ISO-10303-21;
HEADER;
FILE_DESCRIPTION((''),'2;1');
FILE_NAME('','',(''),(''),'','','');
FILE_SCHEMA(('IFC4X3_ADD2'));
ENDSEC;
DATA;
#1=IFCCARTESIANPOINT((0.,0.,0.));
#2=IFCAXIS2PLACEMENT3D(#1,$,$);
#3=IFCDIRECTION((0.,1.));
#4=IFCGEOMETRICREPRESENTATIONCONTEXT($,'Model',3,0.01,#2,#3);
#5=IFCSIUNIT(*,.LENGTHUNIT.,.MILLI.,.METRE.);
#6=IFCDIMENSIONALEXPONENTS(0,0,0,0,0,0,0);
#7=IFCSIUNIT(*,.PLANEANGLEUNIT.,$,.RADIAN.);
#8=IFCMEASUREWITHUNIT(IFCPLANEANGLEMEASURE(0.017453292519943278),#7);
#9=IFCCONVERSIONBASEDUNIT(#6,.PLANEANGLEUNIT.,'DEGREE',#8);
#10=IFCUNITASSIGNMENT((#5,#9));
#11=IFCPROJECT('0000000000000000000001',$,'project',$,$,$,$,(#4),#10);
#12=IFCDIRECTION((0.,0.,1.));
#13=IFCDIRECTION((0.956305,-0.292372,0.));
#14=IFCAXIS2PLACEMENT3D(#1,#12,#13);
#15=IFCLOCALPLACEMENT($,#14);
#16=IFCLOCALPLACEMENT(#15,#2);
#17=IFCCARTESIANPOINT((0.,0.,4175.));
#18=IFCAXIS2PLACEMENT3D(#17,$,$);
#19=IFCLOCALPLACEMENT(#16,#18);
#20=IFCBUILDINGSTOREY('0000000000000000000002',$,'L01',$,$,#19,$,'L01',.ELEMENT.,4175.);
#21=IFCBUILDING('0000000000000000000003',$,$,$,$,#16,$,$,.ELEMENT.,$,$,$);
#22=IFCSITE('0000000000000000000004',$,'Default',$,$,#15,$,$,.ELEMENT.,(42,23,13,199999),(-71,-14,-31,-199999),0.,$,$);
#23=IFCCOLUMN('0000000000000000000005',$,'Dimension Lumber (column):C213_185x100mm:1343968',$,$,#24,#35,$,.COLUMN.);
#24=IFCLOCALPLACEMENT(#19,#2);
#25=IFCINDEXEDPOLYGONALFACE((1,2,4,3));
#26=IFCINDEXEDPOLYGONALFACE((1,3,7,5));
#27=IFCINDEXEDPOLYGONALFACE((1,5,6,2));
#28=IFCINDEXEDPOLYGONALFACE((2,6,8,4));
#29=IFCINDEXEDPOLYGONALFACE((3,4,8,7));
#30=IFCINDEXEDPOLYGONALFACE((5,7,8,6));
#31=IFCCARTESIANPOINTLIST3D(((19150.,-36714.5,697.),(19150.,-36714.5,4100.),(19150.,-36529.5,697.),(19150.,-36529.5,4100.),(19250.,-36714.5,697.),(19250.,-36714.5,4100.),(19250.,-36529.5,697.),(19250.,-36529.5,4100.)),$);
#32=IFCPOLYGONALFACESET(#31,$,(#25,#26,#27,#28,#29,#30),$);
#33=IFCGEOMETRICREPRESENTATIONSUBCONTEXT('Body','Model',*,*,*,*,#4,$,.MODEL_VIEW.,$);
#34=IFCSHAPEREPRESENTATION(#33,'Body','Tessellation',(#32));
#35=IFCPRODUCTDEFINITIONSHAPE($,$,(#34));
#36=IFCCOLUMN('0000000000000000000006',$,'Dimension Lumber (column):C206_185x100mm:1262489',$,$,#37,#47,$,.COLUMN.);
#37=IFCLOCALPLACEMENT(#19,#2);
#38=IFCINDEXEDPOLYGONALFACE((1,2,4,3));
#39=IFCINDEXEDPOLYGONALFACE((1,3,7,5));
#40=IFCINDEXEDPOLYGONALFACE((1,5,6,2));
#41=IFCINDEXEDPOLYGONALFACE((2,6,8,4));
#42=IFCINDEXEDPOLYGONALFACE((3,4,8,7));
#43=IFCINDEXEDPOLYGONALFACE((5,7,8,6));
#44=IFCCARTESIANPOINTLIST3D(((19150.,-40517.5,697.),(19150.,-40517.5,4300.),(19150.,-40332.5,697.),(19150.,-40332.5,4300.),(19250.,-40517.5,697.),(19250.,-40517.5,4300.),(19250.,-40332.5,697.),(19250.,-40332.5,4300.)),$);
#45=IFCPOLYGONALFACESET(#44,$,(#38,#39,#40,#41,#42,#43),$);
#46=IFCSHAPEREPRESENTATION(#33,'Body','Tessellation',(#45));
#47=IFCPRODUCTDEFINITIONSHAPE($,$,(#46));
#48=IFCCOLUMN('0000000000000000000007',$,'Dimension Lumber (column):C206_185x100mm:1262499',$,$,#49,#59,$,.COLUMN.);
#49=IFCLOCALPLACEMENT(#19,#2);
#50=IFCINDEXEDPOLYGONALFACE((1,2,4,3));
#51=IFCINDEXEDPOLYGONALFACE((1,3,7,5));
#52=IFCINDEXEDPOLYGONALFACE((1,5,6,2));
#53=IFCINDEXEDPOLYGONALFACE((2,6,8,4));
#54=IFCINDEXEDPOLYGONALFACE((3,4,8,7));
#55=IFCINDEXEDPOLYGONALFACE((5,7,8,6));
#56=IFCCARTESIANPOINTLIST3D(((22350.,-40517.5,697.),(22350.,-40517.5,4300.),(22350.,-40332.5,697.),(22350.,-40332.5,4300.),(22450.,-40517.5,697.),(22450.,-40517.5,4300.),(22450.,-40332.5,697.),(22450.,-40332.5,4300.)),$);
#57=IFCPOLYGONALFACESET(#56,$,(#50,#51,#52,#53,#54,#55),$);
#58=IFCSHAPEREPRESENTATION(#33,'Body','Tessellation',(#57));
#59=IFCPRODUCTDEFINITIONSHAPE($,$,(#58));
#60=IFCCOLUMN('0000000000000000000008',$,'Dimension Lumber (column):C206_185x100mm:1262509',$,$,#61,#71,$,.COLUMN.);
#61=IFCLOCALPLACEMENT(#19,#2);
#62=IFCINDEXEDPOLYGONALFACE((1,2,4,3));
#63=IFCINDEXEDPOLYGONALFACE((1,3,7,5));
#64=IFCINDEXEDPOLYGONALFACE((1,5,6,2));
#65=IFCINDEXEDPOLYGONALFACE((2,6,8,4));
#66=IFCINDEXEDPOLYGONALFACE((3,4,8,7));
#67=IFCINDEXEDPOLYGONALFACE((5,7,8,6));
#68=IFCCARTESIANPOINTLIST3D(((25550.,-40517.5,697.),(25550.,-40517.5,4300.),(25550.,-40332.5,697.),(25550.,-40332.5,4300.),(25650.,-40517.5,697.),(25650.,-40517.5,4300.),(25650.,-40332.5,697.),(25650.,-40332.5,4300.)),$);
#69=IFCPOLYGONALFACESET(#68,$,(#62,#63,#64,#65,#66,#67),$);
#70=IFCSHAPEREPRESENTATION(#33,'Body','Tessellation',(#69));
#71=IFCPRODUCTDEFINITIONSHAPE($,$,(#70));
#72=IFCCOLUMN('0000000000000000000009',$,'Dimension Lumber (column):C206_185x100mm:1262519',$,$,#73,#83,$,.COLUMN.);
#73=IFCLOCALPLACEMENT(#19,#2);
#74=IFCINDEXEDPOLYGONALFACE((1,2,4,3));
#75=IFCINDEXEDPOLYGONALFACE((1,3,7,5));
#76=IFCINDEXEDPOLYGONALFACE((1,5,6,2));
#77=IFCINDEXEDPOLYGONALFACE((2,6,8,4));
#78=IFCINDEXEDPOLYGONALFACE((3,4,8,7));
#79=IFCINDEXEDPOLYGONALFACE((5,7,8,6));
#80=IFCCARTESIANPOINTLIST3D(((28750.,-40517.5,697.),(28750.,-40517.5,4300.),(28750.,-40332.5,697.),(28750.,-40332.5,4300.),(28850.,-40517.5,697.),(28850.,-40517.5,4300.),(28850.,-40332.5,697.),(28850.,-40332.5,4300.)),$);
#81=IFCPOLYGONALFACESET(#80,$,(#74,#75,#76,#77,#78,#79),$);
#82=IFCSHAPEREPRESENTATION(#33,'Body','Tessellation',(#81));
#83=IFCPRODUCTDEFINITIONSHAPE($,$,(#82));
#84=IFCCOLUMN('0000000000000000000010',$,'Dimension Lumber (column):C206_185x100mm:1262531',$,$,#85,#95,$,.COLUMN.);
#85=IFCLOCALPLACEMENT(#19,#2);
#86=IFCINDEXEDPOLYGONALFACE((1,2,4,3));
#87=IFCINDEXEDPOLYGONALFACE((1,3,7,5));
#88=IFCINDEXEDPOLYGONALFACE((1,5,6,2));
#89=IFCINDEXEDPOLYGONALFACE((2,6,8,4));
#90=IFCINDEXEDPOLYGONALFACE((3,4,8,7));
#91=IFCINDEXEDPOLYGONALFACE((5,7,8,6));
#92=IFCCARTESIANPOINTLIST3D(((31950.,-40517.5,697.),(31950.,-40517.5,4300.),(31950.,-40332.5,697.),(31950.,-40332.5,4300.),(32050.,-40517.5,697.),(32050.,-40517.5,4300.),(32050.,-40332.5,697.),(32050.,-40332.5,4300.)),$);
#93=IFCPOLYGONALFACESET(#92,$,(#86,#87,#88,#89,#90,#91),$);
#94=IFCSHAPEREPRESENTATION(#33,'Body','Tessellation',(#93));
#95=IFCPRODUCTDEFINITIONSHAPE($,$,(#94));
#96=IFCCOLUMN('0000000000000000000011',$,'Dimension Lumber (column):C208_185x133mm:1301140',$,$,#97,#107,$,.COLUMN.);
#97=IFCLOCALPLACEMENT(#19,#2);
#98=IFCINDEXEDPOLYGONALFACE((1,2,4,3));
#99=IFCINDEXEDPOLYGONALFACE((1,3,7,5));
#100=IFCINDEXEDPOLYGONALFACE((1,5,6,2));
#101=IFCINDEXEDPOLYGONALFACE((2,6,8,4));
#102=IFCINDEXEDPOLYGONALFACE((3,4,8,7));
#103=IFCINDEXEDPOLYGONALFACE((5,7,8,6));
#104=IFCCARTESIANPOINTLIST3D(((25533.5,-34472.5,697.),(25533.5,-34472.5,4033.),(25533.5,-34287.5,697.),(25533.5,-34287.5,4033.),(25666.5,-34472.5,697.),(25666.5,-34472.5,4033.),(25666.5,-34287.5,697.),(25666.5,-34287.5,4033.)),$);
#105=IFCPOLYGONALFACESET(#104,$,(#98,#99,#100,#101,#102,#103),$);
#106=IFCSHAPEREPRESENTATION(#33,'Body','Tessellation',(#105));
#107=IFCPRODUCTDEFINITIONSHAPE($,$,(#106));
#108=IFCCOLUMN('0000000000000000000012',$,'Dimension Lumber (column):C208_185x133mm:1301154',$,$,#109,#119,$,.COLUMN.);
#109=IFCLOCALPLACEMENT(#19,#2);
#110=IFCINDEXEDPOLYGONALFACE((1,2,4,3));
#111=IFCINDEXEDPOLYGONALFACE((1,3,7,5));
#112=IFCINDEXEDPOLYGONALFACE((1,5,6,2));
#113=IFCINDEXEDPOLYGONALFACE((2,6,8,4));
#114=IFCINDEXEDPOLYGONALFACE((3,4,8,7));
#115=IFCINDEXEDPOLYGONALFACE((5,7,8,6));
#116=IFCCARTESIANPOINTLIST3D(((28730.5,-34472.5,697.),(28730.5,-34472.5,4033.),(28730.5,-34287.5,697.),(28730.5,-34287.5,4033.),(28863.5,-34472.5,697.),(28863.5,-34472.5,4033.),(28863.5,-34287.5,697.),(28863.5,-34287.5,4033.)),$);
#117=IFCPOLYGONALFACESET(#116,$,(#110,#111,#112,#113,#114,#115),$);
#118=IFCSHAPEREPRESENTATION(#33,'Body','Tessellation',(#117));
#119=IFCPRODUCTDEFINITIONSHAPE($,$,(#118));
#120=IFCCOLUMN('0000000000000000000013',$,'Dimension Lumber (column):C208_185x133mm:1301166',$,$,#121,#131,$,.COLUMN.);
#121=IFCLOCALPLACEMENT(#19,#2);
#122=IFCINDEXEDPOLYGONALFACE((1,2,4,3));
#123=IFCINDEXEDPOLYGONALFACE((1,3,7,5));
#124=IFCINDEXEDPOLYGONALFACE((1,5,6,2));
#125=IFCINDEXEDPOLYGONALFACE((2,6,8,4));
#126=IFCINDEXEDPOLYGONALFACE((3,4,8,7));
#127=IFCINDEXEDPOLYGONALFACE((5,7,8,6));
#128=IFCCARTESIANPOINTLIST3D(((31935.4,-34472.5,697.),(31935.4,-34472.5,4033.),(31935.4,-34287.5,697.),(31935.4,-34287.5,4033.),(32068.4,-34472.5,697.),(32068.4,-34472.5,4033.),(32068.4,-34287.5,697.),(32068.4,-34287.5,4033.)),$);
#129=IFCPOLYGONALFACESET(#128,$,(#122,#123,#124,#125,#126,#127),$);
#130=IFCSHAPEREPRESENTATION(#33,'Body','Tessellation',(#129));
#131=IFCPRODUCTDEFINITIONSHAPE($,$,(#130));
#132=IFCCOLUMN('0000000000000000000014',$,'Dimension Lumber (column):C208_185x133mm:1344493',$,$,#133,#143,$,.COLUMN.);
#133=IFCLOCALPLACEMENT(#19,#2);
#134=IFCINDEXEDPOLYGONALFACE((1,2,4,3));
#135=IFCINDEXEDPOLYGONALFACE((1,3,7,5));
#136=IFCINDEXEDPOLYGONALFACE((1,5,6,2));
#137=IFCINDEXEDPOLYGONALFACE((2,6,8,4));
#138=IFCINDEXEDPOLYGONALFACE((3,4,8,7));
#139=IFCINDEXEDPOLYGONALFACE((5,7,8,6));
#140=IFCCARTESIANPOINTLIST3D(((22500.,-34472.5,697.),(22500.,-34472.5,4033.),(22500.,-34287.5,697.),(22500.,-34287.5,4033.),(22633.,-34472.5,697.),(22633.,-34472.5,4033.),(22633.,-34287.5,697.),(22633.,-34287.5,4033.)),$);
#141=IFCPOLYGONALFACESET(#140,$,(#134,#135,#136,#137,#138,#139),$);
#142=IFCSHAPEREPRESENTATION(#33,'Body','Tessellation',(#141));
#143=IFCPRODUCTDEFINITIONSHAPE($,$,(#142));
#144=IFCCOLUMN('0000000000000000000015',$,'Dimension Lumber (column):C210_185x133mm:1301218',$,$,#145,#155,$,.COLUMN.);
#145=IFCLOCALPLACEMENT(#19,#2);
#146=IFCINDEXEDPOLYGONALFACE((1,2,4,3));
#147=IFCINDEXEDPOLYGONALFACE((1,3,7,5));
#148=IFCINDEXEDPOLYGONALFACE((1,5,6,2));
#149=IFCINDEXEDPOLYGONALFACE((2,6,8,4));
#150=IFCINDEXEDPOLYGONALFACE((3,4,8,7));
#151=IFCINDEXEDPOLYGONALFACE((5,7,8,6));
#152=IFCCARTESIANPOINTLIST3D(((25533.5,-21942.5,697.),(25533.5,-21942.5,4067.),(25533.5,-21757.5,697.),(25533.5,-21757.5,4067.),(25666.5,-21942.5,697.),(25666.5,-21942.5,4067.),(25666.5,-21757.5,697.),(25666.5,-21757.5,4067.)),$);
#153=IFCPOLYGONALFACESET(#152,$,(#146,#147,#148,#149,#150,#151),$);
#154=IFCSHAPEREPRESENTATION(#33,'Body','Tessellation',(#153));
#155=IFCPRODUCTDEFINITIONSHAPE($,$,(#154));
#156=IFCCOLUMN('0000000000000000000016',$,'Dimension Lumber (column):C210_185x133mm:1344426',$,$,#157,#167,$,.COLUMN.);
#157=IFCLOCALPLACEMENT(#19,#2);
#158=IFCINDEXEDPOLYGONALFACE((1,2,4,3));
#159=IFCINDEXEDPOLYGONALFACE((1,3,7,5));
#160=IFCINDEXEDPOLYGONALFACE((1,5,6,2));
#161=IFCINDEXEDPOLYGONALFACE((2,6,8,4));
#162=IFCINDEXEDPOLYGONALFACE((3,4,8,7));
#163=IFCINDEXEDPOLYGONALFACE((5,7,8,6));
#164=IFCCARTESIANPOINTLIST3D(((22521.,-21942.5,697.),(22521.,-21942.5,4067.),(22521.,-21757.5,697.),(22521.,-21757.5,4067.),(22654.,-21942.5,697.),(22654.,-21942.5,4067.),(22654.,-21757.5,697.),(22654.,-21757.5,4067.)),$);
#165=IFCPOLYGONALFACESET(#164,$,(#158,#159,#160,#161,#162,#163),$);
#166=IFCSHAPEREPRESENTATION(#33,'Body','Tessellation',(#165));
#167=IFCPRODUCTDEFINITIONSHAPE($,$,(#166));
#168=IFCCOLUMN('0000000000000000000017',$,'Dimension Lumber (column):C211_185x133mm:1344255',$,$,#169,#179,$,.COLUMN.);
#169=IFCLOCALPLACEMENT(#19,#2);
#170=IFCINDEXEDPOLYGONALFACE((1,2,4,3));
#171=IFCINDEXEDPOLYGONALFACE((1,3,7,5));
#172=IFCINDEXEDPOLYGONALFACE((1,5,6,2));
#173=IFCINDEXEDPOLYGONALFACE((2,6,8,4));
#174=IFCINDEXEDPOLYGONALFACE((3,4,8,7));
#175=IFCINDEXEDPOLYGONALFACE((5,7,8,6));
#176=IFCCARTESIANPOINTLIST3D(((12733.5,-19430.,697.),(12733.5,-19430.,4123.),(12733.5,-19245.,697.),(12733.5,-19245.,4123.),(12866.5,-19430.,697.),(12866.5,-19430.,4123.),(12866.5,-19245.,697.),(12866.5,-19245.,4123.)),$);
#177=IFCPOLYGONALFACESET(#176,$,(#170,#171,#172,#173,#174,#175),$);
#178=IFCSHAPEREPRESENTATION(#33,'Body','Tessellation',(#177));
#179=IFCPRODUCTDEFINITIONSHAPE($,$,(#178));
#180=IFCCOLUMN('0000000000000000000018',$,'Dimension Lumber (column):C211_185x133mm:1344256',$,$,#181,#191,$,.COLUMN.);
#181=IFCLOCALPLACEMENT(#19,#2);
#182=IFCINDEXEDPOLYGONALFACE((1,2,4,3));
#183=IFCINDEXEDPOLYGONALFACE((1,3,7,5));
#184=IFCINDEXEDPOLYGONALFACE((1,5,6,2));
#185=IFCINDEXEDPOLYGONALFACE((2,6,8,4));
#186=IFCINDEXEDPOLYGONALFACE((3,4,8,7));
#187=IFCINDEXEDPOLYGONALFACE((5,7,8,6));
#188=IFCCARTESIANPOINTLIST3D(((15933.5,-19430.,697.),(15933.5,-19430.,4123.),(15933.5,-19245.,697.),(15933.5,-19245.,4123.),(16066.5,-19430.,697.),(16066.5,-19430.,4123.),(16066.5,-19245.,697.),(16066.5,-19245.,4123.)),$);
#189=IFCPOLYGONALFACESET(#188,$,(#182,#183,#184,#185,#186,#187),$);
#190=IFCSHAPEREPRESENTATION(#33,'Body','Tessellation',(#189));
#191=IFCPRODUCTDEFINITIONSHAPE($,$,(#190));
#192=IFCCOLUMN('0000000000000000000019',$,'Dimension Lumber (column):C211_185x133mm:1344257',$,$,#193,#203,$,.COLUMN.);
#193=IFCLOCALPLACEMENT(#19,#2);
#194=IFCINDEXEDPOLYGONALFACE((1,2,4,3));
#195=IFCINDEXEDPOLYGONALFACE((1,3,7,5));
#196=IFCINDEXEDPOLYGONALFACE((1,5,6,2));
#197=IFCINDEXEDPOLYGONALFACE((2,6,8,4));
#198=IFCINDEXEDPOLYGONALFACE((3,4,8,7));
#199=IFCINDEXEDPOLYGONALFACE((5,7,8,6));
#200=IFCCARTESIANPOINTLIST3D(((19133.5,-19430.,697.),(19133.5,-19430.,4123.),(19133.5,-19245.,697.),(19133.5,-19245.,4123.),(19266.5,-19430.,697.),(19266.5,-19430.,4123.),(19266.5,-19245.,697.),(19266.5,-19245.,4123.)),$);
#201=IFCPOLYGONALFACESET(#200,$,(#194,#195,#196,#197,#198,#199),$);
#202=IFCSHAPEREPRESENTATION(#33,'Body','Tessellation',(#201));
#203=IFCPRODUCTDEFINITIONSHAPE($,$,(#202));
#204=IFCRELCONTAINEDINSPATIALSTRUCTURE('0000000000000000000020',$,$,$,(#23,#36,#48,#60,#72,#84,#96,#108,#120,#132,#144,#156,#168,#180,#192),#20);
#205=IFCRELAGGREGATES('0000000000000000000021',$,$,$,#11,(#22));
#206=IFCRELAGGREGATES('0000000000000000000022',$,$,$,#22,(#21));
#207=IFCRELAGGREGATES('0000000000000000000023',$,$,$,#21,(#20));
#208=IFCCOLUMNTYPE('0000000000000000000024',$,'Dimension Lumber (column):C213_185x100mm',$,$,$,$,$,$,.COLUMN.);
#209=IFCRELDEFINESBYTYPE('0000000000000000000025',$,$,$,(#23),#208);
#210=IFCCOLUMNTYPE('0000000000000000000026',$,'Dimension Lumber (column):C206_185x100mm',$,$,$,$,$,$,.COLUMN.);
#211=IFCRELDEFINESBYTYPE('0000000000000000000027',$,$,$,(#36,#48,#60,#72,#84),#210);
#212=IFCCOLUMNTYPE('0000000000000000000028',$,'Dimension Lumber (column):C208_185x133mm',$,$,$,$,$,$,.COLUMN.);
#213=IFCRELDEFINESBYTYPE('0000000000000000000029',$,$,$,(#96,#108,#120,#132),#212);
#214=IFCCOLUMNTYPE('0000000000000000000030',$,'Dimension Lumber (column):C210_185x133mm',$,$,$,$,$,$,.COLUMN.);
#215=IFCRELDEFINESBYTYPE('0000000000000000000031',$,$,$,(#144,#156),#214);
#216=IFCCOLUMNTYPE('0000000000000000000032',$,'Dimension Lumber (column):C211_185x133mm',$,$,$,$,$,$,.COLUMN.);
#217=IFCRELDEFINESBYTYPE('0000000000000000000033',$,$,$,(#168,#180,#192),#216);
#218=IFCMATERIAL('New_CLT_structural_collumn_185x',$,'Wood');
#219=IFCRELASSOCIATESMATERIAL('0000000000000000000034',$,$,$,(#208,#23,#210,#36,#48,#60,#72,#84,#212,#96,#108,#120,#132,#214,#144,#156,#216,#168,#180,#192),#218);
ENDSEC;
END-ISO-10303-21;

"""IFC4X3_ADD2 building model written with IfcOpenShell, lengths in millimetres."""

from ifc_helpers import new_model, entity, si_unit, converted_unit, direction, frame, origin, origin_2d_with_axis, place, context, subcontext, project, spatial, rectangle, extrude, source, transform, mapped, material, material_profile, profile_set, profile_usage, type_object, type_shapes, element, save


model = new_model("IFC4X3_ADD2")

# Units and contexts
model_context = context("Model", 3, precision=0.01, world=origin(), true_north=direction((0.0, 1.0)))
body_context = subcontext(model_context, "Body", "Model", "MODEL_VIEW")
ifc_project = project(units=[si_unit("LENGTHUNIT", "METRE", prefix="MILLI"), converted_unit("PLANEANGLEUNIT", "DEGREE", entity("IfcPlaneAngleMeasure", 0.017453292519943278), si_unit("PLANEANGLEUNIT", "RADIAN"), dimensions=[0, 0, 0, 0, 0, 0, 0])], contexts=[model_context])

# Site, building, storey
site_placement = place(None, frame((0.0, 0.0, 0.0), z_axis=(0.0, 0.0, 1.0), x_axis=(0.956305, -0.292372, 0.0)))
site = spatial("IfcSite", under=ifc_project, at=site_placement, Name="Default", CompositionType="ELEMENT", RefLatitude=(42, 23, 13, 199999), RefLongitude=(-71, -14, -31, -199999), RefElevation=0.0)
building_placement = place(site_placement, origin())
building = spatial("IfcBuilding", under=site, at=building_placement, CompositionType="ELEMENT")
storey_placement = place(building_placement, frame((0.0, 0.0, 4175.0)))
storey = spatial("IfcBuildingStorey", under=building, at=storey_placement, Name="L01", LongName="L01", CompositionType="ELEMENT", Elevation=4175.0)

# Columns
ifc_material_1 = material(Name="New_CLT_structural_collumn_185x", Category="Wood")
ifc_material_profile_1 = material_profile(ifc_material_1, rectangle(XDim=185.0, YDim=100.0, at=origin_2d_with_axis()), Name="C213_185x100mm")
ifc_profile_set_1 = profile_set([ifc_material_profile_1], Name="C213_185x100mm")
ifc_profile_usage_1 = profile_usage(ifc_profile_set_1)
column_type_1 = type_object("IfcColumnType", Name="Dimension Lumber (column):C213_185x100mm", PredefinedType="COLUMN", material=ifc_profile_set_1)
shared_shape_1 = source(origin(), body_context, "Body", "SweptSolid", [
    extrude(rectangle(XDim=185.0, YDim=100.0, at=origin_2d_with_axis()), frame((0.0, 0.0, 4872.0), z_axis=(0.0, 0.0, 1.0), x_axis=(-1.0, 0.0, 0.0)), (0.0, 0.0, 1.0), 3403.0),
])
type_shapes(column_type_1, [shared_shape_1])
column_placement = place(storey_placement, frame((19200.0, -36622.0, -4175.0), z_axis=(0.0, 0.0, 1.0), x_axis=(0.0, -1.0, 0.0)))
element("IfcColumn", 1, at=column_placement, inside=storey, type_object=column_type_1, material=ifc_profile_usage_1, Name="Dimension Lumber (column):C213_185x100mm:1343968", PredefinedType="COLUMN", context=body_context, shape_type="MappedRepresentation", body=[
    mapped(shared_shape_1, transform((0.0, 0.0, 0.0), scale=1.0)),
])
ifc_material_profile_2 = material_profile(ifc_material_1, rectangle(XDim=185.0, YDim=100.0, at=origin_2d_with_axis()), Name="C206_185x100mm")
ifc_profile_set_2 = profile_set([ifc_material_profile_2], Name="C206_185x100mm")
ifc_profile_usage_2 = profile_usage(ifc_profile_set_2)
column_type_2 = type_object("IfcColumnType", Name="Dimension Lumber (column):C206_185x100mm", PredefinedType="COLUMN", material=ifc_profile_set_2)
shared_shape_2 = source(origin(), body_context, "Body", "SweptSolid", [
    extrude(rectangle(XDim=185.0, YDim=100.0, at=origin_2d_with_axis()), frame((0.0, 0.0, 4872.0), z_axis=(0.0, 0.0, 1.0), x_axis=(-1.0, 0.0, 0.0)), (0.0, 0.0, 1.0), 3603.0),
])
type_shapes(column_type_2, [shared_shape_2])
for number, where, z_axis, x_axis, name in (
    (2, (19200.0, -40425.0, -4175.0), (0.0, 0.0, 1.0), (0.0, 1.0, 0.0), "Dimension Lumber (column):C206_185x100mm:1262489"),
    (3, (22400.0, -40425.0, -4175.0), (0.0, 0.0, 1.0), (0.0, 1.0, 0.0), "Dimension Lumber (column):C206_185x100mm:1262499"),
    (4, (25600.0, -40425.0, -4175.0), (0.0, 0.0, 1.0), (0.0, 1.0, 0.0), "Dimension Lumber (column):C206_185x100mm:1262509"),
    (5, (28800.0, -40425.0, -4175.0), (0.0, 0.0, 1.0), (0.0, 1.0, 0.0), "Dimension Lumber (column):C206_185x100mm:1262519"),
    (6, (32000.0, -40425.0, -4175.0), (0.0, 0.0, 1.0), (0.0, 1.0, 0.0), "Dimension Lumber (column):C206_185x100mm:1262531"),
):
    element("IfcColumn", number, at=place(storey_placement, frame(where, z_axis=z_axis, x_axis=x_axis)), inside=storey, type_object=column_type_2, material=ifc_profile_usage_2, Name=name, PredefinedType="COLUMN", context=body_context, shape_type="MappedRepresentation", body=[
        mapped(shared_shape_2, transform((0.0, 0.0, 0.0), scale=1.0)),
    ])
ifc_material_profile_3 = material_profile(ifc_material_1, rectangle(XDim=185.0, YDim=133.0, at=origin_2d_with_axis()), Name="C208_185x133mm")
ifc_profile_set_3 = profile_set([ifc_material_profile_3], Name="C208_185x133mm")
ifc_profile_usage_3 = profile_usage(ifc_profile_set_3)
column_type_3 = type_object("IfcColumnType", Name="Dimension Lumber (column):C208_185x133mm", PredefinedType="COLUMN", material=ifc_profile_set_3)
shared_shape_3 = source(origin(), body_context, "Body", "SweptSolid", [
    extrude(rectangle(XDim=185.0, YDim=133.0, at=origin_2d_with_axis()), frame((0.0, 0.0, 4872.0), z_axis=(0.0, 0.0, 1.0), x_axis=(-1.0, 0.0, 0.0)), (0.0, 0.0, 1.0), 3336.0),
])
type_shapes(column_type_3, [shared_shape_3])
for number, where, z_axis, x_axis, name in (
    (7, (25600.0, -34380.0, -4175.0), (0.0, 0.0, 1.0), (0.0, 1.0, 0.0), "Dimension Lumber (column):C208_185x133mm:1301140"),
    (8, (28797.0, -34380.0, -4175.0), (0.0, 0.0, 1.0), (0.0, 1.0, 0.0), "Dimension Lumber (column):C208_185x133mm:1301154"),
    (9, (32001.9, -34380.0, -4175.0), (0.0, 0.0, 1.0), (0.0, 1.0, 0.0), "Dimension Lumber (column):C208_185x133mm:1301166"),
    (10, (22566.5, -34380.0, -4175.0), (0.0, 0.0, 1.0), (0.0, 1.0, 0.0), "Dimension Lumber (column):C208_185x133mm:1344493"),
):
    element("IfcColumn", number, at=place(storey_placement, frame(where, z_axis=z_axis, x_axis=x_axis)), inside=storey, type_object=column_type_3, material=ifc_profile_usage_3, Name=name, PredefinedType="COLUMN", context=body_context, shape_type="MappedRepresentation", body=[
        mapped(shared_shape_3, transform((0.0, 0.0, 0.0), scale=1.0)),
    ])
ifc_material_profile_4 = material_profile(ifc_material_1, rectangle(XDim=185.0, YDim=133.0, at=origin_2d_with_axis()), Name="C210_185x133mm")
ifc_profile_set_4 = profile_set([ifc_material_profile_4], Name="C210_185x133mm")
ifc_profile_usage_4 = profile_usage(ifc_profile_set_4)
column_type_4 = type_object("IfcColumnType", Name="Dimension Lumber (column):C210_185x133mm", PredefinedType="COLUMN", material=ifc_profile_set_4)
shared_shape_4 = source(origin(), body_context, "Body", "SweptSolid", [
    extrude(rectangle(XDim=185.0, YDim=133.0, at=origin_2d_with_axis()), frame((0.0, 0.0, 4872.0), z_axis=(0.0, 0.0, 1.0), x_axis=(-1.0, 0.0, 0.0)), (0.0, 0.0, 1.0), 3370.0),
])
type_shapes(column_type_4, [shared_shape_4])
for number, where, z_axis, x_axis, name in (
    (11, (25600.0, -21850.0, -4175.0), (0.0, 0.0, 1.0), (0.0, 1.0, 0.0), "Dimension Lumber (column):C210_185x133mm:1301218"),
    (12, (22587.5, -21850.0, -4175.0), (0.0, 0.0, 1.0), (0.0, 1.0, 0.0), "Dimension Lumber (column):C210_185x133mm:1344426"),
):
    element("IfcColumn", number, at=place(storey_placement, frame(where, z_axis=z_axis, x_axis=x_axis)), inside=storey, type_object=column_type_4, material=ifc_profile_usage_4, Name=name, PredefinedType="COLUMN", context=body_context, shape_type="MappedRepresentation", body=[
        mapped(shared_shape_4, transform((0.0, 0.0, 0.0), scale=1.0)),
    ])
ifc_material_profile_5 = material_profile(ifc_material_1, rectangle(XDim=185.0, YDim=133.0, at=origin_2d_with_axis()), Name="C211_185x133mm")
ifc_profile_set_5 = profile_set([ifc_material_profile_5], Name="C211_185x133mm")
ifc_profile_usage_5 = profile_usage(ifc_profile_set_5)
column_type_5 = type_object("IfcColumnType", Name="Dimension Lumber (column):C211_185x133mm", PredefinedType="COLUMN", material=ifc_profile_set_5)
shared_shape_5 = source(origin(), body_context, "Body", "SweptSolid", [
    extrude(rectangle(XDim=185.0, YDim=133.0, at=origin_2d_with_axis()), frame((0.0, 0.0, 4872.0), z_axis=(0.0, 0.0, 1.0), x_axis=(-1.0, 0.0, 0.0)), (0.0, 0.0, 1.0), 3426.0),
])
type_shapes(column_type_5, [shared_shape_5])
for number, where, z_axis, x_axis, name in (
    (13, (12800.0, -19337.5, -4175.0), (0.0, 0.0, 1.0), (0.0, 1.0, 0.0), "Dimension Lumber (column):C211_185x133mm:1344255"),
    (14, (16000.0, -19337.5, -4175.0), (0.0, 0.0, 1.0), (0.0, 1.0, 0.0), "Dimension Lumber (column):C211_185x133mm:1344256"),
    (15, (19200.0, -19337.5, -4175.0), (0.0, 0.0, 1.0), (0.0, 1.0, 0.0), "Dimension Lumber (column):C211_185x133mm:1344257"),
):
    element("IfcColumn", number, at=place(storey_placement, frame(where, z_axis=z_axis, x_axis=x_axis)), inside=storey, type_object=column_type_5, material=ifc_profile_usage_5, Name=name, PredefinedType="COLUMN", context=body_context, shape_type="MappedRepresentation", body=[
        mapped(shared_shape_5, transform((0.0, 0.0, 0.0), scale=1.0)),
    ])

save(model, "model.ifc")
